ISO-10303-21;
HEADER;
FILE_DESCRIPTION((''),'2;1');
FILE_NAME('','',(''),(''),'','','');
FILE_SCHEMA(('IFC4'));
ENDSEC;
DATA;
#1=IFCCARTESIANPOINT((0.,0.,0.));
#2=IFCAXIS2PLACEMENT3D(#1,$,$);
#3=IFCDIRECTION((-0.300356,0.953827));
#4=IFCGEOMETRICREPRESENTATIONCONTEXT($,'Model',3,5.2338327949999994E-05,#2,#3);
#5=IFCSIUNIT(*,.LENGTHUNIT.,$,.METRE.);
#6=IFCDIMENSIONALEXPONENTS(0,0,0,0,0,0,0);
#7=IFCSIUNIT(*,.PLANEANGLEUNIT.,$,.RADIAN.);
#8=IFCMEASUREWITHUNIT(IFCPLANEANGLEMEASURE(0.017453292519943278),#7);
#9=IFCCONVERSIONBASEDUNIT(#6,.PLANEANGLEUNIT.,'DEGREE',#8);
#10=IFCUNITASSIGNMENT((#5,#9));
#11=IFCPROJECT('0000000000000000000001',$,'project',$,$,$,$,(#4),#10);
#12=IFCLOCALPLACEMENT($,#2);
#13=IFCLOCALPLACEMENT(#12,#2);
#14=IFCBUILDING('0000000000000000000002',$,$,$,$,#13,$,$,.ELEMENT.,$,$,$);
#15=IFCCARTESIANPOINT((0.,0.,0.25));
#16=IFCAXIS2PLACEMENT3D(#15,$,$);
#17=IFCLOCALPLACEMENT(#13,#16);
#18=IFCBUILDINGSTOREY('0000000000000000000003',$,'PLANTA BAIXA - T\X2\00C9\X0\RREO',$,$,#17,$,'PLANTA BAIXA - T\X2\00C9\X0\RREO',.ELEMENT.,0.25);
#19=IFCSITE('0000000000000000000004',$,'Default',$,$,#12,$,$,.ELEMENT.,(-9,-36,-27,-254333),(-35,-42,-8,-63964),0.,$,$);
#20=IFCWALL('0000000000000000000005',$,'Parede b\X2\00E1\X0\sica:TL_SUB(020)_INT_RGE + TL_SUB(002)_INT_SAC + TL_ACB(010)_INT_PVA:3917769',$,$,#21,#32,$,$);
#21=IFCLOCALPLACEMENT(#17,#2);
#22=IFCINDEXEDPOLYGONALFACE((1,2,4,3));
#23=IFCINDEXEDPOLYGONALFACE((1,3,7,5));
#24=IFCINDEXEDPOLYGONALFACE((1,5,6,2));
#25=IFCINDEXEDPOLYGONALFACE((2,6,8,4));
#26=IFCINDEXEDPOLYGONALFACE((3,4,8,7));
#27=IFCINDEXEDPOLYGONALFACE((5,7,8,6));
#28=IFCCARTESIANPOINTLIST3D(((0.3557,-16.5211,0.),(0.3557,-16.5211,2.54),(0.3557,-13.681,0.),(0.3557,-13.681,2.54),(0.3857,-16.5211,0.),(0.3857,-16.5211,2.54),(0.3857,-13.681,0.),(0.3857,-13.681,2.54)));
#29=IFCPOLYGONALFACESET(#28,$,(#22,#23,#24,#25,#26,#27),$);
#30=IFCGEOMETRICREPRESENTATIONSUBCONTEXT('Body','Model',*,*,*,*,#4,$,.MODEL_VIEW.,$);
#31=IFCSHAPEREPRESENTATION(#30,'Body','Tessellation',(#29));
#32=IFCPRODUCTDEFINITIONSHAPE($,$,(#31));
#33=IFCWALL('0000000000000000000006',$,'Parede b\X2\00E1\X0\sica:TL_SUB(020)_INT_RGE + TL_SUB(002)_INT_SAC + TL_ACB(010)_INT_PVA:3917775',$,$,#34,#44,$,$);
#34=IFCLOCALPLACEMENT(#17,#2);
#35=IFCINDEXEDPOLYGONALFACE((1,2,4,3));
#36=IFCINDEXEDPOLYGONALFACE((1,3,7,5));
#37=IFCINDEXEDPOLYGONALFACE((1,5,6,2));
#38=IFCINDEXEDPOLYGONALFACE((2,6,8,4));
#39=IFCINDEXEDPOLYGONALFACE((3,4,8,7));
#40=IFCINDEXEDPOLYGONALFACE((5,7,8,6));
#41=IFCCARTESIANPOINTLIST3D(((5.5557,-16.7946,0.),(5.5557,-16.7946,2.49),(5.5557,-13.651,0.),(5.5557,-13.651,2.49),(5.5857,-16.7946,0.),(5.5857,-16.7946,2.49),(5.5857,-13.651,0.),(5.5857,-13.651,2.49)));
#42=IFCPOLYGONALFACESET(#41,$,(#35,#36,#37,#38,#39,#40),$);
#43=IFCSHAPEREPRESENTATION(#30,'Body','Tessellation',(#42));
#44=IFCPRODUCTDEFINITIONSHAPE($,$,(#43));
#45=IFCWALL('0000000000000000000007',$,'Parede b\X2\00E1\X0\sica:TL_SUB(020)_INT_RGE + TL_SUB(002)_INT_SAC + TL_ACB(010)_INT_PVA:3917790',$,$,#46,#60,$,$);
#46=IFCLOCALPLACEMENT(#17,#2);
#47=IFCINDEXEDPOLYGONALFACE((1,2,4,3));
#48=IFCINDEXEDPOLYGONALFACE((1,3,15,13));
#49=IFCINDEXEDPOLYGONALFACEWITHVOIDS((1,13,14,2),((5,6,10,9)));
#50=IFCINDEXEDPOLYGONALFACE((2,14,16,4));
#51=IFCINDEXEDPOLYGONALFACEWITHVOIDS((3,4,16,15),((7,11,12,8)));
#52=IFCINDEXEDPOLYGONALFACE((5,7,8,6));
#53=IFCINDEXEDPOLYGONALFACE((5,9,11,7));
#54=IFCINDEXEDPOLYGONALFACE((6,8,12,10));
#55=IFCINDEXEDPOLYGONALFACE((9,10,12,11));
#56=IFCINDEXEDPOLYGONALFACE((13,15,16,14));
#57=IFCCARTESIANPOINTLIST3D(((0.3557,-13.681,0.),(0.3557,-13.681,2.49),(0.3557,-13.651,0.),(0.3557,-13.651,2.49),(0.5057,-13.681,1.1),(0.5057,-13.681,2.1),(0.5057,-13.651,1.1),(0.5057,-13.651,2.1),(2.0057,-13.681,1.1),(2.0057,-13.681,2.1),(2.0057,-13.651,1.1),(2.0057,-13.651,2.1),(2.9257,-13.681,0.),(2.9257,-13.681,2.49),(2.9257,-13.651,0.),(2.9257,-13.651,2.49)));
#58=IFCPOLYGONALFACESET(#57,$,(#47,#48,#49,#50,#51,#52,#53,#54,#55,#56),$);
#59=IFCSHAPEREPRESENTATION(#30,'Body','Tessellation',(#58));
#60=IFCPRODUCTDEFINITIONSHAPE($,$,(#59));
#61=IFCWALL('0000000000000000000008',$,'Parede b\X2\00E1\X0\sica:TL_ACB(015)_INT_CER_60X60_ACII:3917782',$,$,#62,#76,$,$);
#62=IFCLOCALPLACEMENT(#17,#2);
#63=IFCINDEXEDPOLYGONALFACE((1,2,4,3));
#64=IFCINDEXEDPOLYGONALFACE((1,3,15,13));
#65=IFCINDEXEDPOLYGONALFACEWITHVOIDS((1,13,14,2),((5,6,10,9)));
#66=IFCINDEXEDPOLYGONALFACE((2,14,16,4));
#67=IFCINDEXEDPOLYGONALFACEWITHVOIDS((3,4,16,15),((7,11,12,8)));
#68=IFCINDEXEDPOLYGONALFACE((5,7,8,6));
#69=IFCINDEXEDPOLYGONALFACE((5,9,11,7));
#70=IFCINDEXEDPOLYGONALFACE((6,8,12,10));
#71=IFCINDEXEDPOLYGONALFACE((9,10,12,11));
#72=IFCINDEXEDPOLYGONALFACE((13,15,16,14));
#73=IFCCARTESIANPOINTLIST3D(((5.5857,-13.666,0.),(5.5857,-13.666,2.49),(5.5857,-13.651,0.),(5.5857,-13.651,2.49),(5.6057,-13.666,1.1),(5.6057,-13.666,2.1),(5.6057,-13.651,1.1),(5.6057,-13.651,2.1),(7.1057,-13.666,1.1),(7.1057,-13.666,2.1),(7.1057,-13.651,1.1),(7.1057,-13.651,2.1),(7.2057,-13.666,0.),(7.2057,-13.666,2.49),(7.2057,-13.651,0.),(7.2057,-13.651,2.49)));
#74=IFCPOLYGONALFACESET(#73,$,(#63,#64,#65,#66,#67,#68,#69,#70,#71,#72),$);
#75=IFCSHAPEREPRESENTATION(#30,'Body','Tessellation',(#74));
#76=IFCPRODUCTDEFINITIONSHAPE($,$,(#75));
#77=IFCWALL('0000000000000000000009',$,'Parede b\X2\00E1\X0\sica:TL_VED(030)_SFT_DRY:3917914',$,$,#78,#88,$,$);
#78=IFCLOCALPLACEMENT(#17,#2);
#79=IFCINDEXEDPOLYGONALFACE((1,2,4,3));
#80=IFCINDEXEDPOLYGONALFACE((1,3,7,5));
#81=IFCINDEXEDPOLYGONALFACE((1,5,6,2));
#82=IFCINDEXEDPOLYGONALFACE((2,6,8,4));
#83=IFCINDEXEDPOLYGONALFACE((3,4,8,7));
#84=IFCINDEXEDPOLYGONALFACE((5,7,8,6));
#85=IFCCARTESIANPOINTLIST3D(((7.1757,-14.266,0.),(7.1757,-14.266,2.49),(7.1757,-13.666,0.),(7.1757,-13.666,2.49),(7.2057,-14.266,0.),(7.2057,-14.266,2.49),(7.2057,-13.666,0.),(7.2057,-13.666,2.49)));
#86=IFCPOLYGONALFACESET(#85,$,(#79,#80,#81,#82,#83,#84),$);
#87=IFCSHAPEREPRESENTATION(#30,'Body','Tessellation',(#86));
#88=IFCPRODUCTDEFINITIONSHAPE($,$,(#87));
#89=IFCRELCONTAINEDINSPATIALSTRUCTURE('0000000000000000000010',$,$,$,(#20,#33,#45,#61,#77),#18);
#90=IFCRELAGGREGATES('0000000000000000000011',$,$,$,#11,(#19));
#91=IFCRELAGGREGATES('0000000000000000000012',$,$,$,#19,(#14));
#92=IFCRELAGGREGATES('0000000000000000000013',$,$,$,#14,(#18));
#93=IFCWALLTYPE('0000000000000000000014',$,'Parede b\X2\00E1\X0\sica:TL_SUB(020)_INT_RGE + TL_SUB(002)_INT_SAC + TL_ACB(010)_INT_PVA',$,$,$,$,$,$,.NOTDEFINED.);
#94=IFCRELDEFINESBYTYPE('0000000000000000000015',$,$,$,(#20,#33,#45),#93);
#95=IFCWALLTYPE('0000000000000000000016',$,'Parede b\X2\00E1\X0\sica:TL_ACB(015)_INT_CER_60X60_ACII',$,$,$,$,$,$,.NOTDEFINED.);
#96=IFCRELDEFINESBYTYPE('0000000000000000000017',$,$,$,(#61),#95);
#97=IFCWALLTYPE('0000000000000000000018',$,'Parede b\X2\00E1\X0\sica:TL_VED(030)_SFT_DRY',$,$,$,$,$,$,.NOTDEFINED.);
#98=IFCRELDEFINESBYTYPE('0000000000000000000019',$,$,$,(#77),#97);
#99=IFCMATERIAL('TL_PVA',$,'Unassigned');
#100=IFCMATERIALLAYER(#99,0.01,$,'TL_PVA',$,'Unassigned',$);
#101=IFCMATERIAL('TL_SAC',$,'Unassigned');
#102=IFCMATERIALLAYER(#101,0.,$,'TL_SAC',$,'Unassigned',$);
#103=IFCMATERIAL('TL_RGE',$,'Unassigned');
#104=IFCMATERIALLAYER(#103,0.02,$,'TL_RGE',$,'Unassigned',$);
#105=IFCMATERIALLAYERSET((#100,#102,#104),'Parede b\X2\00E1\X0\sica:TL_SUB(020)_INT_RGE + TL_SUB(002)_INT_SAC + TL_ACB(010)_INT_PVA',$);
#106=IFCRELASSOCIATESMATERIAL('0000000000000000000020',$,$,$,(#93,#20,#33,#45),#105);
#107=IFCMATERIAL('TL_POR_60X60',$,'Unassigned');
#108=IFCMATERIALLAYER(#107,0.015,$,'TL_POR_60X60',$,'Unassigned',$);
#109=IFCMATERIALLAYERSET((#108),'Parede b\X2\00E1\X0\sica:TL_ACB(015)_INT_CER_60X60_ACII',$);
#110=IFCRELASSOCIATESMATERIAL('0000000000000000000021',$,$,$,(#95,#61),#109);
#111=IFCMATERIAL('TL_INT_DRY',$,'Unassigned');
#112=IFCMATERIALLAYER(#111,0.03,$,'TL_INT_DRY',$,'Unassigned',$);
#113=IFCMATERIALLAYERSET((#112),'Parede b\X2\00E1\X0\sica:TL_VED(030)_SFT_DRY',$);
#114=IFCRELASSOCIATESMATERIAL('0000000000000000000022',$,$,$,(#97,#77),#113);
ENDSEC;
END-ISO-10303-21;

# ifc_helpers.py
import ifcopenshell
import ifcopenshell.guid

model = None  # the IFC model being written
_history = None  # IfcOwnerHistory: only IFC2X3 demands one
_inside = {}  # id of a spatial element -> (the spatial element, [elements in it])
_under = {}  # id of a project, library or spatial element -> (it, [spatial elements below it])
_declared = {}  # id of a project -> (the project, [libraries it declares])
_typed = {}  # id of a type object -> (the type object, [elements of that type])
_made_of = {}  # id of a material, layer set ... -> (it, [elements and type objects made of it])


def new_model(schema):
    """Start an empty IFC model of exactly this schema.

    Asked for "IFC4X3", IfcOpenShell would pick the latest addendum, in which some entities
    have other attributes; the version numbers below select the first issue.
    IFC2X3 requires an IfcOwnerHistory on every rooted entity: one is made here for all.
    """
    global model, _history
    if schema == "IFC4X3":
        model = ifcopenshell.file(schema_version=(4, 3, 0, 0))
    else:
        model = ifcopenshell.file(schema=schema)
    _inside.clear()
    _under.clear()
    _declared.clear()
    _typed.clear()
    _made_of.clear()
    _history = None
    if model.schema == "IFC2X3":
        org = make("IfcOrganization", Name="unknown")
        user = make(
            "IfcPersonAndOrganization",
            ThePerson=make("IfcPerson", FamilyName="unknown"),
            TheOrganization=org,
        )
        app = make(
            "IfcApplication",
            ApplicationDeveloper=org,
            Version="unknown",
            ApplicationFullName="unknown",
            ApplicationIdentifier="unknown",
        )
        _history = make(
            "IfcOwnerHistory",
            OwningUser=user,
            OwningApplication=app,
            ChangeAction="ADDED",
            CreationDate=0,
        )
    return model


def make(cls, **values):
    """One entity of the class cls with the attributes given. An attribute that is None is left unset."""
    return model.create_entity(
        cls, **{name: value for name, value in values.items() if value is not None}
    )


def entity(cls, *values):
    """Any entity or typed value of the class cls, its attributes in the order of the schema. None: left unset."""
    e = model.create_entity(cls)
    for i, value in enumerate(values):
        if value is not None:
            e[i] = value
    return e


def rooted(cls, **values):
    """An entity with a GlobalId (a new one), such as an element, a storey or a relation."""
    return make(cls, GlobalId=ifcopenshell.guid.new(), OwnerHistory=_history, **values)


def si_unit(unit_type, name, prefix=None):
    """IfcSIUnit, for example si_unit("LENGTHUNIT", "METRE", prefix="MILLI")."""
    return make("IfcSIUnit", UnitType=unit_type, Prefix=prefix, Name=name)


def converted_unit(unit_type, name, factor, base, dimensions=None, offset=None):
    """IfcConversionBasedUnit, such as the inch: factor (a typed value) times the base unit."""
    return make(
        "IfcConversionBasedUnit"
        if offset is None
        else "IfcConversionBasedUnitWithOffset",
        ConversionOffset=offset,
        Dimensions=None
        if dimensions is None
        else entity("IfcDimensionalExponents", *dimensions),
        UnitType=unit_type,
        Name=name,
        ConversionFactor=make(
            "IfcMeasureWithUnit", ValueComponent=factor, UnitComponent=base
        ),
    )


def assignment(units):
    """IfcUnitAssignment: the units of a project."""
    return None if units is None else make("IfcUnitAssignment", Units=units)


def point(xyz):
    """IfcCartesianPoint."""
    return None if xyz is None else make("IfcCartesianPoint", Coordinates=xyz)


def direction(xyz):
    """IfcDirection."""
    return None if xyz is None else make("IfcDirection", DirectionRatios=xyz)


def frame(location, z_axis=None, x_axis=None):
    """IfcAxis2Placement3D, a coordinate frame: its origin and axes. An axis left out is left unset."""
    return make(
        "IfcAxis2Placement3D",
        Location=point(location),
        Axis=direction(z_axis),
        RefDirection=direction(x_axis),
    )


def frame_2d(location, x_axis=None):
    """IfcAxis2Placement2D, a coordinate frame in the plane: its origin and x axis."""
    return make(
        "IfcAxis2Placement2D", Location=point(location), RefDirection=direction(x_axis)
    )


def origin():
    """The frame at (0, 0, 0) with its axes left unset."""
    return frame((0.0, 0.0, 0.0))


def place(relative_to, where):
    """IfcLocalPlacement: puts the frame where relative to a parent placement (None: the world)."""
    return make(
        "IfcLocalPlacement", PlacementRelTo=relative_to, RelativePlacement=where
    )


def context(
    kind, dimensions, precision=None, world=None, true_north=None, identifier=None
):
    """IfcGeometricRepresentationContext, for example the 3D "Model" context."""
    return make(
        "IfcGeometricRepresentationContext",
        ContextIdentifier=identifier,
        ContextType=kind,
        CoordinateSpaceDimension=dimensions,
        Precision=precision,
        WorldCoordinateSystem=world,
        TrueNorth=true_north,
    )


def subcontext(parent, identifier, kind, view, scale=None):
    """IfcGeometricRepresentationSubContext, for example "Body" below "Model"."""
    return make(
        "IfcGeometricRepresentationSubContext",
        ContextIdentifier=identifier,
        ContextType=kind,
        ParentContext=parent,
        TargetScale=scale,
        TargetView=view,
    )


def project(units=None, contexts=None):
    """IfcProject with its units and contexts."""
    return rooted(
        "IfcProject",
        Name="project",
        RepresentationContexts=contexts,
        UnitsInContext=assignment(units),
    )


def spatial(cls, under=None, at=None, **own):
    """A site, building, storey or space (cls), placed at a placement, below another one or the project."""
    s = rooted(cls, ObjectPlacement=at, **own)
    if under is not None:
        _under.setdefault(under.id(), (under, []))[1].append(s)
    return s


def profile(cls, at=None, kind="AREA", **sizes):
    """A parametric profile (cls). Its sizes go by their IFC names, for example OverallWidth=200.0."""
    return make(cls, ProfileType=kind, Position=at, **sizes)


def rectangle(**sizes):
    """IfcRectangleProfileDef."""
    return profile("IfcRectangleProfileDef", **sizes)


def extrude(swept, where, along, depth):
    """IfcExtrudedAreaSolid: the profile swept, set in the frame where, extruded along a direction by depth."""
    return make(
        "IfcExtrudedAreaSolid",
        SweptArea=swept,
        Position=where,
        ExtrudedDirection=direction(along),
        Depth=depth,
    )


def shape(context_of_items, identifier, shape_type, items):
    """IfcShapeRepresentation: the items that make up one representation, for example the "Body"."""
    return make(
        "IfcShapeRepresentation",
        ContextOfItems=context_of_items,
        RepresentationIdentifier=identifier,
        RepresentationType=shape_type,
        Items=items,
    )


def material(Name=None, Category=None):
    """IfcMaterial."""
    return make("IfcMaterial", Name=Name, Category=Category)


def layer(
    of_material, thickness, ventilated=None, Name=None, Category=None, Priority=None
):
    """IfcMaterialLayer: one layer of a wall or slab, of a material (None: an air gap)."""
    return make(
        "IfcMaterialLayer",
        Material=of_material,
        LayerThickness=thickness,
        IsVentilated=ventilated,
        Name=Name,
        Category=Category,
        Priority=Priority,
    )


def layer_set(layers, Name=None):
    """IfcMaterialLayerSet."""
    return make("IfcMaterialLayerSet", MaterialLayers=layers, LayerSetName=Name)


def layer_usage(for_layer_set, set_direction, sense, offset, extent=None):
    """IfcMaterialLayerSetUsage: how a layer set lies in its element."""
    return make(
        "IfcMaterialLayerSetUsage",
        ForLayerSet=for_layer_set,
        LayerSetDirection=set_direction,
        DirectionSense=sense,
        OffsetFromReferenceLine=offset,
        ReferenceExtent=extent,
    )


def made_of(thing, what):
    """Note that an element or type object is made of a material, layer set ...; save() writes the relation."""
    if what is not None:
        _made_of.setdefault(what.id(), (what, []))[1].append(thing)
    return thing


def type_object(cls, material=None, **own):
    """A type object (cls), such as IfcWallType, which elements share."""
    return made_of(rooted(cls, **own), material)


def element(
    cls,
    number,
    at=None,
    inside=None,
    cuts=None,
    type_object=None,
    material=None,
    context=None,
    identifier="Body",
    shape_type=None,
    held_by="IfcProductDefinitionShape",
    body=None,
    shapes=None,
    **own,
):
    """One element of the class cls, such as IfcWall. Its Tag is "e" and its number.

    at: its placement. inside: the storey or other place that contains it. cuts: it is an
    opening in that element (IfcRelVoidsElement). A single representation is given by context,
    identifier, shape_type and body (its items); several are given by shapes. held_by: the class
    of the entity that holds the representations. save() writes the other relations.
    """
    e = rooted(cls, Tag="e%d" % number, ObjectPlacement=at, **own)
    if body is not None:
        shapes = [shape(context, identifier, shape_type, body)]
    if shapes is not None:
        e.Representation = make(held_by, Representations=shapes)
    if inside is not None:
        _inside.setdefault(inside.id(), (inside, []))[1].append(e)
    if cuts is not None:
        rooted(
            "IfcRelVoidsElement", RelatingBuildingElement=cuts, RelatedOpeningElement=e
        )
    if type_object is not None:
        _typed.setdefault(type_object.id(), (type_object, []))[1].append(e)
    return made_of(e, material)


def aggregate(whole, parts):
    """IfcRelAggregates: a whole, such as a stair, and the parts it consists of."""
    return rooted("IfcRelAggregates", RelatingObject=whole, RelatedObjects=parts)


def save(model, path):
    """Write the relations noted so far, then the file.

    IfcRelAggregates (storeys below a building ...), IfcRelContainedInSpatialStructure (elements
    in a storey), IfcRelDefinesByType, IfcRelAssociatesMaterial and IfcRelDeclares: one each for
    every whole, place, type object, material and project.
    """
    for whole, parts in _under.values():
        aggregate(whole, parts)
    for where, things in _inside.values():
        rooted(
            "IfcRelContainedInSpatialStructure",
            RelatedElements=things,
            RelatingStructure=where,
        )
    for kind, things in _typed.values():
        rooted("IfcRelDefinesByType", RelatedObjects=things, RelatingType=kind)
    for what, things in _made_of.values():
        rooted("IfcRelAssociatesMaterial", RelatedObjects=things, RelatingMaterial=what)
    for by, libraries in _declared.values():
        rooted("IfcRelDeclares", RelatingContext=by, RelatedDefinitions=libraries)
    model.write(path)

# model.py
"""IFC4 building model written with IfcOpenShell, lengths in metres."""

from ifc_helpers import new_model, entity, si_unit, converted_unit, direction, frame, frame_2d, origin, place, context, subcontext, project, spatial, rectangle, extrude, material, layer, layer_set, layer_usage, type_object, element, save


model = new_model("IFC4")

# Units and contexts
model_context = context("Model", 3, precision=5.2338327949999994e-05, world=origin(), true_north=direction((-0.300356, 0.953827)))
body_context = subcontext(model_context, "Body", "Model", "MODEL_VIEW")
ifc_project = project(units=[si_unit("LENGTHUNIT", "METRE"), converted_unit("PLANEANGLEUNIT", "DEGREE", entity("IfcPlaneAngleMeasure", 0.017453292519943278), si_unit("PLANEANGLEUNIT", "RADIAN"), dimensions=[0, 0, 0, 0, 0, 0, 0])], contexts=[model_context])

# Site, building, storey
site_placement = place(None, origin())
site = spatial("IfcSite", under=ifc_project, at=site_placement, Name="Default", CompositionType="ELEMENT", RefLatitude=(-9, -36, -27, -254333), RefLongitude=(-35, -42, -8, -63964), RefElevation=0.0)
building_placement = place(site_placement, origin())
building = spatial("IfcBuilding", under=site, at=building_placement, CompositionType="ELEMENT")
storey_placement = place(building_placement, frame((0.0, 0.0, 0.25)))
storey = spatial("IfcBuildingStorey", under=building, at=storey_placement, Name="PLANTA BAIXA - TÉRREO", LongName="PLANTA BAIXA - TÉRREO", CompositionType="ELEMENT", Elevation=0.25)

# Walls
ifc_material_1 = material(Name="TL_PVA", Category="Unassigned")
ifc_layer_1 = layer(ifc_material_1, 0.01, Name="TL_PVA", Category="Unassigned")
ifc_material_2 = material(Name="TL_SAC", Category="Unassigned")
ifc_layer_2 = layer(ifc_material_2, 0.0, Name="TL_SAC", Category="Unassigned")
ifc_material_3 = material(Name="TL_RGE", Category="Unassigned")
ifc_layer_3 = layer(ifc_material_3, 0.02, Name="TL_RGE", Category="Unassigned")
ifc_layer_set_1 = layer_set([ifc_layer_1, ifc_layer_2, ifc_layer_3], Name="Parede básica:TL_SUB(020)_INT_RGE + TL_SUB(002)_INT_SAC + TL_ACB(010)_INT_PVA")
ifc_layer_usage_1 = layer_usage(ifc_layer_set_1, "AXIS2", "NEGATIVE", 0.015)
wall_type_1 = type_object("IfcWallType", Name="Parede básica:TL_SUB(020)_INT_RGE + TL_SUB(002)_INT_SAC + TL_ACB(010)_INT_PVA", PredefinedType="NOTDEFINED", material=ifc_layer_set_1)
wall_1_placement = place(storey_placement, frame((0.3707, -13.681, 0.0), z_axis=(0.0, 0.0, 1.0), x_axis=(0.0, -1.0, 0.0)))
element("IfcWall", 1, at=wall_1_placement, inside=storey, type_object=wall_type_1, material=ifc_layer_usage_1, Name="Parede básica:TL_SUB(020)_INT_RGE + TL_SUB(002)_INT_SAC + TL_ACB(010)_INT_PVA:3917769", context=body_context, shape_type="SweptSolid", body=[
    extrude(rectangle(XDim=2.8401, YDim=0.03, at=frame_2d((1.4201, 0.0), x_axis=(-1.0, 0.0))), origin(), (0.0, 0.0, 1.0), 2.54),
])
ifc_layer_usage_2 = layer_usage(ifc_layer_set_1, "AXIS2", "NEGATIVE", 0.015)
wall_2_placement = place(storey_placement, frame((5.5707, -13.651, 0.0), z_axis=(0.0, 0.0, 1.0), x_axis=(0.0, -1.0, 0.0)))
element("IfcWall", 2, at=wall_2_placement, inside=storey, type_object=wall_type_1, material=ifc_layer_usage_2, Name="Parede básica:TL_SUB(020)_INT_RGE + TL_SUB(002)_INT_SAC + TL_ACB(010)_INT_PVA:3917775", context=body_context, shape_type="SweptSolid", body=[
    extrude(rectangle(XDim=3.1437, YDim=0.03, at=frame_2d((1.5718, 0.0), x_axis=(-1.0, 0.0))), origin(), (0.0, 0.0, 1.0), 2.49),
])

# Walls, openings
ifc_layer_usage_3 = layer_usage(ifc_layer_set_1, "AXIS2", "NEGATIVE", 0.015)
wall_3_placement = place(storey_placement, frame((2.9257, -13.666, 0.0), z_axis=(0.0, 0.0, 1.0), x_axis=(-1.0, 0.0, 0.0)))
wall_3 = element("IfcWall", 3, at=wall_3_placement, inside=storey, type_object=wall_type_1, material=ifc_layer_usage_3, Name="Parede básica:TL_SUB(020)_INT_RGE + TL_SUB(002)_INT_SAC + TL_ACB(010)_INT_PVA:3917790", context=body_context, shape_type="SweptSolid", body=[
    extrude(rectangle(XDim=2.57, YDim=0.03, at=frame_2d((1.285, 0.0), x_axis=(-1.0, 0.0))), origin(), (0.0, 0.0, 1.0), 2.49),
])
opening_1_placement = place(wall_3_placement, frame((2.9257, -13.666, 1.1)))
element("IfcOpeningElement", 4, at=opening_1_placement, cuts=wall_3, PredefinedType="OPENING", context=body_context, shape_type="SweptSolid", body=[
    extrude(rectangle(XDim=1.0, YDim=1.5, at=frame_2d((0.0, 0.0), x_axis=(0.0, 1.0))), frame((-1.2557, 12.127, 0.5), z_axis=(0.0, 1.0, 0.0), x_axis=(1.0, 0.0, 0.0)), (0.0, 0.0, 1.0), 3.048),
])
ifc_material_4 = material(Name="TL_POR_60X60", Category="Unassigned")
ifc_layer_4 = layer(ifc_material_4, 0.015, Name="TL_POR_60X60", Category="Unassigned")
ifc_layer_set_2 = layer_set([ifc_layer_4], Name="Parede básica:TL_ACB(015)_INT_CER_60X60_ACII")
ifc_layer_usage_4 = layer_usage(ifc_layer_set_2, "AXIS2", "NEGATIVE", 0.0075)
wall_type_2 = type_object("IfcWallType", Name="Parede básica:TL_ACB(015)_INT_CER_60X60_ACII", PredefinedType="NOTDEFINED", material=ifc_layer_set_2)
wall_4_placement = place(storey_placement, frame((7.2057, -13.6585, 0.0), z_axis=(0.0, 0.0, 1.0), x_axis=(-1.0, 0.0, 0.0)))
wall_4 = element("IfcWall", 5, at=wall_4_placement, inside=storey, type_object=wall_type_2, material=ifc_layer_usage_4, Name="Parede básica:TL_ACB(015)_INT_CER_60X60_ACII:3917782", context=body_context, shape_type="SweptSolid", body=[
    extrude(rectangle(XDim=1.62, YDim=0.015, at=frame_2d((0.81, 0.0), x_axis=(-1.0, 0.0))), origin(), (0.0, 0.0, 1.0), 2.49),
])
opening_2_placement = place(wall_4_placement, frame((7.2057, -13.6585, 1.1)))
element("IfcOpeningElement", 6, at=opening_2_placement, cuts=wall_4, PredefinedType="OPENING", context=body_context, shape_type="SweptSolid", body=[
    extrude(rectangle(XDim=1.0, YDim=1.5, at=frame_2d((0.0, 0.0), x_axis=(0.0, 1.0))), frame((-6.3557, 12.127, 0.5), z_axis=(0.0, 1.0, 0.0), x_axis=(1.0, 0.0, 0.0)), (0.0, 0.0, 1.0), 3.048),
])

# Wall
ifc_material_5 = material(Name="TL_INT_DRY", Category="Unassigned")
ifc_layer_5 = layer(ifc_material_5, 0.03, Name="TL_INT_DRY", Category="Unassigned")
ifc_layer_set_3 = layer_set([ifc_layer_5], Name="Parede básica:TL_VED(030)_SFT_DRY")
ifc_layer_usage_5 = layer_usage(ifc_layer_set_3, "AXIS2", "POSITIVE", -0.015)
wall_type_3 = type_object("IfcWallType", Name="Parede básica:TL_VED(030)_SFT_DRY", PredefinedType="NOTDEFINED", material=ifc_layer_set_3)
wall_5_placement = place(storey_placement, frame((7.1907, -13.666, 0.0), z_axis=(0.0, 0.0, 1.0), x_axis=(0.0, -1.0, 0.0)))
element("IfcWall", 7, at=wall_5_placement, inside=storey, type_object=wall_type_3, material=ifc_layer_usage_5, Name="Parede básica:TL_VED(030)_SFT_DRY:3917914", context=body_context, shape_type="SweptSolid", body=[
    extrude(rectangle(XDim=0.6, YDim=0.03, at=frame_2d((0.3, 0.0), x_axis=(-1.0, 0.0))), origin(), (0.0, 0.0, 1.0), 2.49),
])

save(model, "model.ifc")
